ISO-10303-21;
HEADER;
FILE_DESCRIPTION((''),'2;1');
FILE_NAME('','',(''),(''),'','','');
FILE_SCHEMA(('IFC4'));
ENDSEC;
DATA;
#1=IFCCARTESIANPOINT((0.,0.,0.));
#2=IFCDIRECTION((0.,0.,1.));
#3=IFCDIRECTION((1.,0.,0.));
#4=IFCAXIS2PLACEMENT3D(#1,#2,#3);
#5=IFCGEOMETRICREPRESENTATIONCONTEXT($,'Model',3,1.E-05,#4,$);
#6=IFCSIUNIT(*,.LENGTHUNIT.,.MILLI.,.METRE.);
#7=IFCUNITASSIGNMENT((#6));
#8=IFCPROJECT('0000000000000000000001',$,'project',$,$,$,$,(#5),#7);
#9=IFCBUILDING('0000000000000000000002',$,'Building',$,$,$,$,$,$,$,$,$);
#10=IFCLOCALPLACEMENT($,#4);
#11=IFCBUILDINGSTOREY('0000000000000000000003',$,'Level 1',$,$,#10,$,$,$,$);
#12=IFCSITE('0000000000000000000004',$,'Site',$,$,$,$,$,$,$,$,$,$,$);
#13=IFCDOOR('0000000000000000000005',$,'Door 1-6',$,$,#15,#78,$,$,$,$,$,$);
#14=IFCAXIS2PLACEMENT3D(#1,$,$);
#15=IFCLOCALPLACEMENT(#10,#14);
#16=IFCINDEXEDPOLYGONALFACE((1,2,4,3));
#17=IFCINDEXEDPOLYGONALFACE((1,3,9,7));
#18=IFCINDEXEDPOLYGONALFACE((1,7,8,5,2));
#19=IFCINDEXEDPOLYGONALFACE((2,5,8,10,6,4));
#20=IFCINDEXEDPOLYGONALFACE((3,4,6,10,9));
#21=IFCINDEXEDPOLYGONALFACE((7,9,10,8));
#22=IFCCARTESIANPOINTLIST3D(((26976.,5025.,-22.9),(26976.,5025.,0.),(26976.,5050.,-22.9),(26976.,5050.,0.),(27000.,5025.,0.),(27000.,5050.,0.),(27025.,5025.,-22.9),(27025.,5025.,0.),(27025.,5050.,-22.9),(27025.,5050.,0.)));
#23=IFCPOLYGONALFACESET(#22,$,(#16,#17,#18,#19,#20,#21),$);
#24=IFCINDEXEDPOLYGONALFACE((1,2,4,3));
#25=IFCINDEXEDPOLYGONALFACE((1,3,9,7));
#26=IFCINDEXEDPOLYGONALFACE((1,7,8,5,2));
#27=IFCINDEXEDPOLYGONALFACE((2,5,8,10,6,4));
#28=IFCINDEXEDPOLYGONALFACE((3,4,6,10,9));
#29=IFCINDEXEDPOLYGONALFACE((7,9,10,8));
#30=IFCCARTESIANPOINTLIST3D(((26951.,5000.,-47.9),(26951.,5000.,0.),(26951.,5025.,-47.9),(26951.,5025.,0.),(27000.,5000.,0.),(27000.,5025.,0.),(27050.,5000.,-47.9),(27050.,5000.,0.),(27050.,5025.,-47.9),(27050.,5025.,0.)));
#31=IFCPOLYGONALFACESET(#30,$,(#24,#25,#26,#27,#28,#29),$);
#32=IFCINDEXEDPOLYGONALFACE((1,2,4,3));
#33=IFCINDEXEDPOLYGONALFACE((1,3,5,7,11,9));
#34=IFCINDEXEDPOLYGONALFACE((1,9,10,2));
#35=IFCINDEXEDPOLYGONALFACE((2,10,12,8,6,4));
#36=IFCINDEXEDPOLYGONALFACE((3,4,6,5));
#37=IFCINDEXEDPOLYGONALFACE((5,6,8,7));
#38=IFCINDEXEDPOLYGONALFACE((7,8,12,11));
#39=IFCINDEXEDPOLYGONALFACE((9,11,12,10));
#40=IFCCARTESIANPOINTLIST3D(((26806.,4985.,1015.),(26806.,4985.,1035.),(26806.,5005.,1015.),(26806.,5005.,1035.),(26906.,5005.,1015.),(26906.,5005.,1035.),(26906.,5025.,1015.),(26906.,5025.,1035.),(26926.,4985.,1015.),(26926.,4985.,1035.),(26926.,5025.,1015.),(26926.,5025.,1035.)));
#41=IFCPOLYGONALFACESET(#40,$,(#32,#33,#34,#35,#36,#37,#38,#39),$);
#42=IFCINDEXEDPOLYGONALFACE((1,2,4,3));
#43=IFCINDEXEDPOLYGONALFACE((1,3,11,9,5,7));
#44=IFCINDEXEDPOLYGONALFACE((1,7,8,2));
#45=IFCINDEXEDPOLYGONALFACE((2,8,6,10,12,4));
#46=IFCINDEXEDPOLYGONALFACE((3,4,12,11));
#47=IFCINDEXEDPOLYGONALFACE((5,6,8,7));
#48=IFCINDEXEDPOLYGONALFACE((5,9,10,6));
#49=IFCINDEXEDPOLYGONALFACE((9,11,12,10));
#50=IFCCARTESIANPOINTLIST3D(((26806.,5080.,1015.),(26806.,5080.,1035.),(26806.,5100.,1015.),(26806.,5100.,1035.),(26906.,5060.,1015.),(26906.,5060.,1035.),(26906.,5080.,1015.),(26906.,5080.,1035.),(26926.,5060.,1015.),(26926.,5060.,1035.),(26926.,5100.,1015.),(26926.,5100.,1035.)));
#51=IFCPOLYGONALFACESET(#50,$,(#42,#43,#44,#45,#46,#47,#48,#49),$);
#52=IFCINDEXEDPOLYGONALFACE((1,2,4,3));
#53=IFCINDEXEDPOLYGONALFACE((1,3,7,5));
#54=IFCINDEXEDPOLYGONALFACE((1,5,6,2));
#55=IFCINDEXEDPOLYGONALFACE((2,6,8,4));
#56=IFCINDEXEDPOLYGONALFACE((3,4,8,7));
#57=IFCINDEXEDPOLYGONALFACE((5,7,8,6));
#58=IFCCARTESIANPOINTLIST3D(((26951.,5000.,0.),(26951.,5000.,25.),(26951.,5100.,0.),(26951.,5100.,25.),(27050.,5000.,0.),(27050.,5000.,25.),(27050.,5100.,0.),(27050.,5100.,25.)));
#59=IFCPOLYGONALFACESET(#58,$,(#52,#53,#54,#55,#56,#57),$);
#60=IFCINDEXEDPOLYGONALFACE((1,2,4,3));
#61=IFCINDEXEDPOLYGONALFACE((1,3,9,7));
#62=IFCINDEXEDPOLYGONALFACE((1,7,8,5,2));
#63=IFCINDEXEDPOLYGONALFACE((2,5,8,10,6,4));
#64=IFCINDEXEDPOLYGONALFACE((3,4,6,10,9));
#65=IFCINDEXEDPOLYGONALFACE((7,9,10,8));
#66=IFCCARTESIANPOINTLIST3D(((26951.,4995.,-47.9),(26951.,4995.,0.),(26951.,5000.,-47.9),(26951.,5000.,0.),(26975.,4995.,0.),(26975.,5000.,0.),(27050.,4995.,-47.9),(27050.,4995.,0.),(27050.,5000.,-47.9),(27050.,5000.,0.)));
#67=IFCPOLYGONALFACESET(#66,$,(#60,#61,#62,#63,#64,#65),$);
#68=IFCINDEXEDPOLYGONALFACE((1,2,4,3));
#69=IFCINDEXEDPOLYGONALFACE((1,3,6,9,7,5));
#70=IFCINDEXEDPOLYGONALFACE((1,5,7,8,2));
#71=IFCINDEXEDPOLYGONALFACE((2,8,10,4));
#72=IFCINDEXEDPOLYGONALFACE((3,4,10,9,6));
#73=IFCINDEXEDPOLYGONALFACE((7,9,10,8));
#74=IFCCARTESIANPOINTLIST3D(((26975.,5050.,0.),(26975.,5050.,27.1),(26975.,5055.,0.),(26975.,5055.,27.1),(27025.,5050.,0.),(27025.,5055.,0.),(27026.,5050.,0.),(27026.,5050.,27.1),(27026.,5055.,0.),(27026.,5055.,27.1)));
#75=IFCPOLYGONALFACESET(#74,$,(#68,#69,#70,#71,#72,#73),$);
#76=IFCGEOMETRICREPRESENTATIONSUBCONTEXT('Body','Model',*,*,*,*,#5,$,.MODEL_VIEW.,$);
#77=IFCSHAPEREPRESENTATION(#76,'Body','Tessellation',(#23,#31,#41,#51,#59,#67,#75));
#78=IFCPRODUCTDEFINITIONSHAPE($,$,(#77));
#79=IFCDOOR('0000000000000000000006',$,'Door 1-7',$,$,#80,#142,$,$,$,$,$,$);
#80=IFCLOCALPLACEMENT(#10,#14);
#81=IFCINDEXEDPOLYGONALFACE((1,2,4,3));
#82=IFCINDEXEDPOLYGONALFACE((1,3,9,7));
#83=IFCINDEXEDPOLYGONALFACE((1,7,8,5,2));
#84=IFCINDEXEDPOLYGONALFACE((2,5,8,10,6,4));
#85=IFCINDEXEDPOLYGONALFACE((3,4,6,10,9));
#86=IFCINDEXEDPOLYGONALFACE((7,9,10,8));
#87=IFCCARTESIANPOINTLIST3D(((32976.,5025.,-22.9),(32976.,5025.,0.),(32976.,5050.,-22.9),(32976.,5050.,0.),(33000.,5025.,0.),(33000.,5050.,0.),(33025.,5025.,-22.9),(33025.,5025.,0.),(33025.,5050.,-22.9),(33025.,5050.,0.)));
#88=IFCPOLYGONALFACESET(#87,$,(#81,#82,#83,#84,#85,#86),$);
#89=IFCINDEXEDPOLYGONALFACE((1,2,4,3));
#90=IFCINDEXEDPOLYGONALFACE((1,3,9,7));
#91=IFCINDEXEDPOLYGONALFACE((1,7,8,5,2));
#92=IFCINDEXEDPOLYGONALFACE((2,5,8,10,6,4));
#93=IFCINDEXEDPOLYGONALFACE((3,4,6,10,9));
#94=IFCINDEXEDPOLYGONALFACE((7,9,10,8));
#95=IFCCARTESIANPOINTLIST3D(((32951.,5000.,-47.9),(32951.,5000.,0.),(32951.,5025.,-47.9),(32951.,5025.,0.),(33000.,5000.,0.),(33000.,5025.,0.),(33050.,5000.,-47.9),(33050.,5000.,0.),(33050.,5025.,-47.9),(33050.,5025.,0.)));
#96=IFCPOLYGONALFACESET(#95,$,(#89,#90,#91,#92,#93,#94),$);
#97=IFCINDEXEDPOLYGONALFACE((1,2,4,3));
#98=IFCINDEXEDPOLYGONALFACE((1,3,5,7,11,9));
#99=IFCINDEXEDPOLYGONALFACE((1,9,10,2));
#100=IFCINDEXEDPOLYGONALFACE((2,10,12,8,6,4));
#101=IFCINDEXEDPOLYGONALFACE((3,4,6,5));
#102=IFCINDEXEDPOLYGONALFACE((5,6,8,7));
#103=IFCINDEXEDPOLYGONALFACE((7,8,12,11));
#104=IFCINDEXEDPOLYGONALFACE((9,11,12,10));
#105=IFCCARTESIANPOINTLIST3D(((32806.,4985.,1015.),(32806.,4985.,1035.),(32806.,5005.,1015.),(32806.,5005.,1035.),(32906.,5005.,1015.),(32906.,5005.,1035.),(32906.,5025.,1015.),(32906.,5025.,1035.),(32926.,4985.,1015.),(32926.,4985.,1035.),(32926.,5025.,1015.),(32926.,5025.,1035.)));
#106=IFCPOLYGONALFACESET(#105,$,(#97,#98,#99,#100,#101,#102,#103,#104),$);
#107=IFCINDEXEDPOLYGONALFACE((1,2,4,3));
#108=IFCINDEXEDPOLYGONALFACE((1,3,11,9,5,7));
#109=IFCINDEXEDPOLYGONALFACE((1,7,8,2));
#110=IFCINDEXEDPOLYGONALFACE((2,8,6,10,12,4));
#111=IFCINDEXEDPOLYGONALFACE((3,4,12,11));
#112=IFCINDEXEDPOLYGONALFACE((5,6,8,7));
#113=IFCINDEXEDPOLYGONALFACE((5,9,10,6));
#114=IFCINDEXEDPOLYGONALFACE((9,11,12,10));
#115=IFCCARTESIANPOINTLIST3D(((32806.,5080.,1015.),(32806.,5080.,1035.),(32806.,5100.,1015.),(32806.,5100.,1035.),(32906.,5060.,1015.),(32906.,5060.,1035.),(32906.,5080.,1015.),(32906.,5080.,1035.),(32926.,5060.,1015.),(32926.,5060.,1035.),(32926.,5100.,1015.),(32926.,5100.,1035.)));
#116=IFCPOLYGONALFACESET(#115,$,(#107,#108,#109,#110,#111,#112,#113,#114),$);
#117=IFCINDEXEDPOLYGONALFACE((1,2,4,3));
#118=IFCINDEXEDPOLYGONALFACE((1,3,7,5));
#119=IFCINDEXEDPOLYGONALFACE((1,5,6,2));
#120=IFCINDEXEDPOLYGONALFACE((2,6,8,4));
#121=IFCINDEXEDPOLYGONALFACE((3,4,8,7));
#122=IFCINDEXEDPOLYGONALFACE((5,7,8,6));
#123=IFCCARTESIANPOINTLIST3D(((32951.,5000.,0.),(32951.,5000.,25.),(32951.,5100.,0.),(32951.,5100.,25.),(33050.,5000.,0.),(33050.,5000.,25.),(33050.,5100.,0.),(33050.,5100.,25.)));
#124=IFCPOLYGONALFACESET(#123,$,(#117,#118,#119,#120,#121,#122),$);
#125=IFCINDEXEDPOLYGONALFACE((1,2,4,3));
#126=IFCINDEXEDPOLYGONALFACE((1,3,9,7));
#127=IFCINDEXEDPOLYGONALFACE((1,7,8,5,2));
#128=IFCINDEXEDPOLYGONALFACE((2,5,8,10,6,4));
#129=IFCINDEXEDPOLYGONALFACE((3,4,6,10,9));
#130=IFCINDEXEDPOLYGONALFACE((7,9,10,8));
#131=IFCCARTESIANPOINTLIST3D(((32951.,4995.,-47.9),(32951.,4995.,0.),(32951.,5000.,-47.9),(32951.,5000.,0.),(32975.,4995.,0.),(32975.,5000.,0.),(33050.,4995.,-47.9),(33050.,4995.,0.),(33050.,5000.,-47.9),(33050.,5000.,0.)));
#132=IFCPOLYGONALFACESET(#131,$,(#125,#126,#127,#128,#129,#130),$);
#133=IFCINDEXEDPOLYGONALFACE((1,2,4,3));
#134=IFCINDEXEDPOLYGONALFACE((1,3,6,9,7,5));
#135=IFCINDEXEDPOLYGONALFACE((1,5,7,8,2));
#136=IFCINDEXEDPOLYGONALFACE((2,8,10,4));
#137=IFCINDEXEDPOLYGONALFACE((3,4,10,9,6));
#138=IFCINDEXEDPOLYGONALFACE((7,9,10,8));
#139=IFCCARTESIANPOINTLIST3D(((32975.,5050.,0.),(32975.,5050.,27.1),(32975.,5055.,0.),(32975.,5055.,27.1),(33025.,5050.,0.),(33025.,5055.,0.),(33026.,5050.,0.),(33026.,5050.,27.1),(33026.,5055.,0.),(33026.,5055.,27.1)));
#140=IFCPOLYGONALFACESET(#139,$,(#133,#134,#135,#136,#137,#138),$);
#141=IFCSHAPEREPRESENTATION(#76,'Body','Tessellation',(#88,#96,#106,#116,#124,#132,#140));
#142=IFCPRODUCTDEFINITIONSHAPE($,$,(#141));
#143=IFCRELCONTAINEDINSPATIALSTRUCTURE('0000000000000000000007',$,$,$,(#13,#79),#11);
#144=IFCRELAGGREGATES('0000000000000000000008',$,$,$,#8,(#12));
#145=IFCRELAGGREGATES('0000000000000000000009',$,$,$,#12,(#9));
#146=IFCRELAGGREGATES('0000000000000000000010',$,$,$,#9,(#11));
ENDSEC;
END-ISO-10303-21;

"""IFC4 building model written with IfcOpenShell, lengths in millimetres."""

from ifc_helpers import new_model, si_unit, frame, origin_with_axes, place, context, subcontext, project, spatial, line, indexed_curve, outline, extrude, element, save


model = new_model("IFC4")

# Units and contexts
model_context = context("Model", 3, precision=1e-05, world=origin_with_axes())
body_context = subcontext(model_context, "Body", "Model", "MODEL_VIEW")
ifc_project = project(units=[si_unit("LENGTHUNIT", "METRE", prefix="MILLI")], contexts=[model_context])

# Site, building, storey
site = spatial("IfcSite", under=ifc_project, Name="Site")
building = spatial("IfcBuilding", under=site, Name="Building")
storey_placement = place(None, origin_with_axes())
storey = spatial("IfcBuildingStorey", under=building, at=storey_placement, Name="Level 1")

# Doors
door_1_placement = place(storey_placement, frame((27000.0, 5000.0, 0.0), z_axis=(0.0, 0.0, 1.0), x_axis=(1.0, 0.0, 0.0)))
element("IfcDoor", 1, at=door_1_placement, inside=storey, Name="Door 1-6", context=body_context, shape_type="SweptSolid", body=[
    extrude(outline(indexed_curve([(0.0, 0.0), (0.0, 2.1), (1.0, 2.1), (1.0, 0.0), (-24.0, 0.0), (-24.0, -22.9), (25.0, -22.9), (25.0, 0.0)], segments=[line(1, 2, 3, 4, 5, 6, 7, 8, 1)])), frame((0.0, 25.0, 0.0), z_axis=(0.0, -1.0, 0.0), x_axis=(1.0, 0.0, 0.0)), (0.0, 0.0, -1.0), 25.0),
    extrude(outline(indexed_curve([(0.0, 0.0), (0.0, 2.1), (1.0, 2.1), (1.0, 0.0), (-49.0, 0.0), (-49.0, -47.9), (50.0, -47.9), (50.0, 0.0)], segments=[line(1, 2, 3, 4, 5, 6, 7, 8, 1)])), frame((0.0, 0.0, 0.0), z_axis=(0.0, -1.0, 0.0), x_axis=(1.0, 0.0, 0.0)), (0.0, 0.0, -1.0), 25.0),
    extrude(outline(indexed_curve([(0.0, 0.0), (-49.0, 0.0), (-49.0, 35.0), (0.0, 35.0)], segments=[line(1, 2, 3, 4, 1)])), frame((25.0, 25.0, 25.0), z_axis=(0.0, 0.0, 1.0), x_axis=(1.0, 0.0, 0.0)), (0.0, 0.0, 1.0), -47.9),
    extrude(outline(indexed_curve([(0.0, 0.0), (0.0, -40.0), (-120.0, -40.0), (-120.0, -20.0), (-20.0, -20.0), (-20.0, 0.0)], segments=[line(1, 2, 3, 4, 5, 6, 1)])), frame((-74.0, 25.0, 1015.0), z_axis=(0.0, 0.0, 1.0), x_axis=(1.0, 0.0, 0.0)), (0.0, 0.0, 1.0), 20.0),
    extrude(outline(indexed_curve([(0.0, 0.0), (0.0, 40.0), (-120.0, 40.0), (-120.0, 20.0), (-20.0, 20.0), (-20.0, 0.0)], segments=[line(1, 2, 3, 4, 5, 6, 1)])), frame((-74.0, 60.0, 1015.0), z_axis=(0.0, 0.0, 1.0), x_axis=(1.0, 0.0, 0.0)), (0.0, 0.0, 1.0), 20.0),
    extrude(outline(indexed_curve([(0.0, 0.0), (-99.0, 0.0), (-99.0, 100.0), (0.0, 100.0)], segments=[line(1, 2, 3, 4, 1)])), frame((50.0, 0.0, 0.0), z_axis=(0.0, 0.0, 1.0), x_axis=(1.0, 0.0, 0.0)), (0.0, 0.0, 1.0), 25.0),
    extrude(outline(indexed_curve([(0.0, 0.0), (0.0, 27.1), (51.0, 27.1), (51.0, 0.0), (-24.0, 0.0), (-24.0, -47.9), (75.0, -47.9), (75.0, 0.0)], segments=[line(1, 2, 3, 4, 5, 6, 7, 8, 1)])), frame((-25.0, -5.0, 0.0), z_axis=(0.0, -1.0, 0.0), x_axis=(1.0, 0.0, 0.0)), (0.0, 0.0, -1.0), 5.0),
    extrude(outline(indexed_curve([(0.0, 0.0), (0.0, 27.1), (51.0, 27.1), (51.0, 0.0), (1.0, 0.0), (1.0, -22.9), (50.0, -22.9), (50.0, 0.0)], segments=[line(1, 2, 3, 4, 5, 6, 7, 8, 1)])), frame((-25.0, 50.0, 0.0), z_axis=(0.0, -1.0, 0.0), x_axis=(1.0, 0.0, 0.0)), (0.0, 0.0, -1.0), 5.0),
])
door_2_placement = place(storey_placement, frame((33000.0, 5000.0, 0.0), z_axis=(0.0, 0.0, 1.0), x_axis=(1.0, 0.0, 0.0)))
element("IfcDoor", 2, at=door_2_placement, inside=storey, Name="Door 1-7", context=body_context, shape_type="SweptSolid", body=[
    extrude(outline(indexed_curve([(0.0, 0.0), (0.0, 2.1), (1.0, 2.1), (1.0, 0.0), (-24.0, 0.0), (-24.0, -22.9), (25.0, -22.9), (25.0, 0.0)], segments=[line(1, 2, 3, 4, 5, 6, 7, 8, 1)])), frame((0.0, 25.0, 0.0), z_axis=(0.0, -1.0, 0.0), x_axis=(1.0, 0.0, 0.0)), (0.0, 0.0, -1.0), 25.0),
    extrude(outline(indexed_curve([(0.0, 0.0), (0.0, 2.1), (1.0, 2.1), (1.0, 0.0), (-49.0, 0.0), (-49.0, -47.9), (50.0, -47.9), (50.0, 0.0)], segments=[line(1, 2, 3, 4, 5, 6, 7, 8, 1)])), frame((0.0, 0.0, 0.0), z_axis=(0.0, -1.0, 0.0), x_axis=(1.0, 0.0, 0.0)), (0.0, 0.0, -1.0), 25.0),
    extrude(outline(indexed_curve([(0.0, 0.0), (-49.0, 0.0), (-49.0, 35.0), (0.0, 35.0)], segments=[line(1, 2, 3, 4, 1)])), frame((25.0, 25.0, 25.0), z_axis=(0.0, 0.0, 1.0), x_axis=(1.0, 0.0, 0.0)), (0.0, 0.0, 1.0), -47.9),
    extrude(outline(indexed_curve([(0.0, 0.0), (0.0, -40.0), (-120.0, -40.0), (-120.0, -20.0), (-20.0, -20.0), (-20.0, 0.0)], segments=[line(1, 2, 3, 4, 5, 6, 1)])), frame((-74.0, 25.0, 1015.0), z_axis=(0.0, 0.0, 1.0), x_axis=(1.0, 0.0, 0.0)), (0.0, 0.0, 1.0), 20.0),
    extrude(outline(indexed_curve([(0.0, 0.0), (0.0, 40.0), (-120.0, 40.0), (-120.0, 20.0), (-20.0, 20.0), (-20.0, 0.0)], segments=[line(1, 2, 3, 4, 5, 6, 1)])), frame((-74.0, 60.0, 1015.0), z_axis=(0.0, 0.0, 1.0), x_axis=(1.0, 0.0, 0.0)), (0.0, 0.0, 1.0), 20.0),
    extrude(outline(indexed_curve([(0.0, 0.0), (-99.0, 0.0), (-99.0, 100.0), (0.0, 100.0)], segments=[line(1, 2, 3, 4, 1)])), frame((50.0, 0.0, 0.0), z_axis=(0.0, 0.0, 1.0), x_axis=(1.0, 0.0, 0.0)), (0.0, 0.0, 1.0), 25.0),
    extrude(outline(indexed_curve([(0.0, 0.0), (0.0, 27.1), (51.0, 27.1), (51.0, 0.0), (-24.0, 0.0), (-24.0, -47.9), (75.0, -47.9), (75.0, 0.0)], segments=[line(1, 2, 3, 4, 5, 6, 7, 8, 1)])), frame((-25.0, -5.0, 0.0), z_axis=(0.0, -1.0, 0.0), x_axis=(1.0, 0.0, 0.0)), (0.0, 0.0, -1.0), 5.0),
    extrude(outline(indexed_curve([(0.0, 0.0), (0.0, 27.1), (51.0, 27.1), (51.0, 0.0), (1.0, 0.0), (1.0, -22.9), (50.0, -22.9), (50.0, 0.0)], segments=[line(1, 2, 3, 4, 5, 6, 7, 8, 1)])), frame((-25.0, 50.0, 0.0), z_axis=(0.0, -1.0, 0.0), x_axis=(1.0, 0.0, 0.0)), (0.0, 0.0, -1.0), 5.0),
])

save(model, "model.ifc")
